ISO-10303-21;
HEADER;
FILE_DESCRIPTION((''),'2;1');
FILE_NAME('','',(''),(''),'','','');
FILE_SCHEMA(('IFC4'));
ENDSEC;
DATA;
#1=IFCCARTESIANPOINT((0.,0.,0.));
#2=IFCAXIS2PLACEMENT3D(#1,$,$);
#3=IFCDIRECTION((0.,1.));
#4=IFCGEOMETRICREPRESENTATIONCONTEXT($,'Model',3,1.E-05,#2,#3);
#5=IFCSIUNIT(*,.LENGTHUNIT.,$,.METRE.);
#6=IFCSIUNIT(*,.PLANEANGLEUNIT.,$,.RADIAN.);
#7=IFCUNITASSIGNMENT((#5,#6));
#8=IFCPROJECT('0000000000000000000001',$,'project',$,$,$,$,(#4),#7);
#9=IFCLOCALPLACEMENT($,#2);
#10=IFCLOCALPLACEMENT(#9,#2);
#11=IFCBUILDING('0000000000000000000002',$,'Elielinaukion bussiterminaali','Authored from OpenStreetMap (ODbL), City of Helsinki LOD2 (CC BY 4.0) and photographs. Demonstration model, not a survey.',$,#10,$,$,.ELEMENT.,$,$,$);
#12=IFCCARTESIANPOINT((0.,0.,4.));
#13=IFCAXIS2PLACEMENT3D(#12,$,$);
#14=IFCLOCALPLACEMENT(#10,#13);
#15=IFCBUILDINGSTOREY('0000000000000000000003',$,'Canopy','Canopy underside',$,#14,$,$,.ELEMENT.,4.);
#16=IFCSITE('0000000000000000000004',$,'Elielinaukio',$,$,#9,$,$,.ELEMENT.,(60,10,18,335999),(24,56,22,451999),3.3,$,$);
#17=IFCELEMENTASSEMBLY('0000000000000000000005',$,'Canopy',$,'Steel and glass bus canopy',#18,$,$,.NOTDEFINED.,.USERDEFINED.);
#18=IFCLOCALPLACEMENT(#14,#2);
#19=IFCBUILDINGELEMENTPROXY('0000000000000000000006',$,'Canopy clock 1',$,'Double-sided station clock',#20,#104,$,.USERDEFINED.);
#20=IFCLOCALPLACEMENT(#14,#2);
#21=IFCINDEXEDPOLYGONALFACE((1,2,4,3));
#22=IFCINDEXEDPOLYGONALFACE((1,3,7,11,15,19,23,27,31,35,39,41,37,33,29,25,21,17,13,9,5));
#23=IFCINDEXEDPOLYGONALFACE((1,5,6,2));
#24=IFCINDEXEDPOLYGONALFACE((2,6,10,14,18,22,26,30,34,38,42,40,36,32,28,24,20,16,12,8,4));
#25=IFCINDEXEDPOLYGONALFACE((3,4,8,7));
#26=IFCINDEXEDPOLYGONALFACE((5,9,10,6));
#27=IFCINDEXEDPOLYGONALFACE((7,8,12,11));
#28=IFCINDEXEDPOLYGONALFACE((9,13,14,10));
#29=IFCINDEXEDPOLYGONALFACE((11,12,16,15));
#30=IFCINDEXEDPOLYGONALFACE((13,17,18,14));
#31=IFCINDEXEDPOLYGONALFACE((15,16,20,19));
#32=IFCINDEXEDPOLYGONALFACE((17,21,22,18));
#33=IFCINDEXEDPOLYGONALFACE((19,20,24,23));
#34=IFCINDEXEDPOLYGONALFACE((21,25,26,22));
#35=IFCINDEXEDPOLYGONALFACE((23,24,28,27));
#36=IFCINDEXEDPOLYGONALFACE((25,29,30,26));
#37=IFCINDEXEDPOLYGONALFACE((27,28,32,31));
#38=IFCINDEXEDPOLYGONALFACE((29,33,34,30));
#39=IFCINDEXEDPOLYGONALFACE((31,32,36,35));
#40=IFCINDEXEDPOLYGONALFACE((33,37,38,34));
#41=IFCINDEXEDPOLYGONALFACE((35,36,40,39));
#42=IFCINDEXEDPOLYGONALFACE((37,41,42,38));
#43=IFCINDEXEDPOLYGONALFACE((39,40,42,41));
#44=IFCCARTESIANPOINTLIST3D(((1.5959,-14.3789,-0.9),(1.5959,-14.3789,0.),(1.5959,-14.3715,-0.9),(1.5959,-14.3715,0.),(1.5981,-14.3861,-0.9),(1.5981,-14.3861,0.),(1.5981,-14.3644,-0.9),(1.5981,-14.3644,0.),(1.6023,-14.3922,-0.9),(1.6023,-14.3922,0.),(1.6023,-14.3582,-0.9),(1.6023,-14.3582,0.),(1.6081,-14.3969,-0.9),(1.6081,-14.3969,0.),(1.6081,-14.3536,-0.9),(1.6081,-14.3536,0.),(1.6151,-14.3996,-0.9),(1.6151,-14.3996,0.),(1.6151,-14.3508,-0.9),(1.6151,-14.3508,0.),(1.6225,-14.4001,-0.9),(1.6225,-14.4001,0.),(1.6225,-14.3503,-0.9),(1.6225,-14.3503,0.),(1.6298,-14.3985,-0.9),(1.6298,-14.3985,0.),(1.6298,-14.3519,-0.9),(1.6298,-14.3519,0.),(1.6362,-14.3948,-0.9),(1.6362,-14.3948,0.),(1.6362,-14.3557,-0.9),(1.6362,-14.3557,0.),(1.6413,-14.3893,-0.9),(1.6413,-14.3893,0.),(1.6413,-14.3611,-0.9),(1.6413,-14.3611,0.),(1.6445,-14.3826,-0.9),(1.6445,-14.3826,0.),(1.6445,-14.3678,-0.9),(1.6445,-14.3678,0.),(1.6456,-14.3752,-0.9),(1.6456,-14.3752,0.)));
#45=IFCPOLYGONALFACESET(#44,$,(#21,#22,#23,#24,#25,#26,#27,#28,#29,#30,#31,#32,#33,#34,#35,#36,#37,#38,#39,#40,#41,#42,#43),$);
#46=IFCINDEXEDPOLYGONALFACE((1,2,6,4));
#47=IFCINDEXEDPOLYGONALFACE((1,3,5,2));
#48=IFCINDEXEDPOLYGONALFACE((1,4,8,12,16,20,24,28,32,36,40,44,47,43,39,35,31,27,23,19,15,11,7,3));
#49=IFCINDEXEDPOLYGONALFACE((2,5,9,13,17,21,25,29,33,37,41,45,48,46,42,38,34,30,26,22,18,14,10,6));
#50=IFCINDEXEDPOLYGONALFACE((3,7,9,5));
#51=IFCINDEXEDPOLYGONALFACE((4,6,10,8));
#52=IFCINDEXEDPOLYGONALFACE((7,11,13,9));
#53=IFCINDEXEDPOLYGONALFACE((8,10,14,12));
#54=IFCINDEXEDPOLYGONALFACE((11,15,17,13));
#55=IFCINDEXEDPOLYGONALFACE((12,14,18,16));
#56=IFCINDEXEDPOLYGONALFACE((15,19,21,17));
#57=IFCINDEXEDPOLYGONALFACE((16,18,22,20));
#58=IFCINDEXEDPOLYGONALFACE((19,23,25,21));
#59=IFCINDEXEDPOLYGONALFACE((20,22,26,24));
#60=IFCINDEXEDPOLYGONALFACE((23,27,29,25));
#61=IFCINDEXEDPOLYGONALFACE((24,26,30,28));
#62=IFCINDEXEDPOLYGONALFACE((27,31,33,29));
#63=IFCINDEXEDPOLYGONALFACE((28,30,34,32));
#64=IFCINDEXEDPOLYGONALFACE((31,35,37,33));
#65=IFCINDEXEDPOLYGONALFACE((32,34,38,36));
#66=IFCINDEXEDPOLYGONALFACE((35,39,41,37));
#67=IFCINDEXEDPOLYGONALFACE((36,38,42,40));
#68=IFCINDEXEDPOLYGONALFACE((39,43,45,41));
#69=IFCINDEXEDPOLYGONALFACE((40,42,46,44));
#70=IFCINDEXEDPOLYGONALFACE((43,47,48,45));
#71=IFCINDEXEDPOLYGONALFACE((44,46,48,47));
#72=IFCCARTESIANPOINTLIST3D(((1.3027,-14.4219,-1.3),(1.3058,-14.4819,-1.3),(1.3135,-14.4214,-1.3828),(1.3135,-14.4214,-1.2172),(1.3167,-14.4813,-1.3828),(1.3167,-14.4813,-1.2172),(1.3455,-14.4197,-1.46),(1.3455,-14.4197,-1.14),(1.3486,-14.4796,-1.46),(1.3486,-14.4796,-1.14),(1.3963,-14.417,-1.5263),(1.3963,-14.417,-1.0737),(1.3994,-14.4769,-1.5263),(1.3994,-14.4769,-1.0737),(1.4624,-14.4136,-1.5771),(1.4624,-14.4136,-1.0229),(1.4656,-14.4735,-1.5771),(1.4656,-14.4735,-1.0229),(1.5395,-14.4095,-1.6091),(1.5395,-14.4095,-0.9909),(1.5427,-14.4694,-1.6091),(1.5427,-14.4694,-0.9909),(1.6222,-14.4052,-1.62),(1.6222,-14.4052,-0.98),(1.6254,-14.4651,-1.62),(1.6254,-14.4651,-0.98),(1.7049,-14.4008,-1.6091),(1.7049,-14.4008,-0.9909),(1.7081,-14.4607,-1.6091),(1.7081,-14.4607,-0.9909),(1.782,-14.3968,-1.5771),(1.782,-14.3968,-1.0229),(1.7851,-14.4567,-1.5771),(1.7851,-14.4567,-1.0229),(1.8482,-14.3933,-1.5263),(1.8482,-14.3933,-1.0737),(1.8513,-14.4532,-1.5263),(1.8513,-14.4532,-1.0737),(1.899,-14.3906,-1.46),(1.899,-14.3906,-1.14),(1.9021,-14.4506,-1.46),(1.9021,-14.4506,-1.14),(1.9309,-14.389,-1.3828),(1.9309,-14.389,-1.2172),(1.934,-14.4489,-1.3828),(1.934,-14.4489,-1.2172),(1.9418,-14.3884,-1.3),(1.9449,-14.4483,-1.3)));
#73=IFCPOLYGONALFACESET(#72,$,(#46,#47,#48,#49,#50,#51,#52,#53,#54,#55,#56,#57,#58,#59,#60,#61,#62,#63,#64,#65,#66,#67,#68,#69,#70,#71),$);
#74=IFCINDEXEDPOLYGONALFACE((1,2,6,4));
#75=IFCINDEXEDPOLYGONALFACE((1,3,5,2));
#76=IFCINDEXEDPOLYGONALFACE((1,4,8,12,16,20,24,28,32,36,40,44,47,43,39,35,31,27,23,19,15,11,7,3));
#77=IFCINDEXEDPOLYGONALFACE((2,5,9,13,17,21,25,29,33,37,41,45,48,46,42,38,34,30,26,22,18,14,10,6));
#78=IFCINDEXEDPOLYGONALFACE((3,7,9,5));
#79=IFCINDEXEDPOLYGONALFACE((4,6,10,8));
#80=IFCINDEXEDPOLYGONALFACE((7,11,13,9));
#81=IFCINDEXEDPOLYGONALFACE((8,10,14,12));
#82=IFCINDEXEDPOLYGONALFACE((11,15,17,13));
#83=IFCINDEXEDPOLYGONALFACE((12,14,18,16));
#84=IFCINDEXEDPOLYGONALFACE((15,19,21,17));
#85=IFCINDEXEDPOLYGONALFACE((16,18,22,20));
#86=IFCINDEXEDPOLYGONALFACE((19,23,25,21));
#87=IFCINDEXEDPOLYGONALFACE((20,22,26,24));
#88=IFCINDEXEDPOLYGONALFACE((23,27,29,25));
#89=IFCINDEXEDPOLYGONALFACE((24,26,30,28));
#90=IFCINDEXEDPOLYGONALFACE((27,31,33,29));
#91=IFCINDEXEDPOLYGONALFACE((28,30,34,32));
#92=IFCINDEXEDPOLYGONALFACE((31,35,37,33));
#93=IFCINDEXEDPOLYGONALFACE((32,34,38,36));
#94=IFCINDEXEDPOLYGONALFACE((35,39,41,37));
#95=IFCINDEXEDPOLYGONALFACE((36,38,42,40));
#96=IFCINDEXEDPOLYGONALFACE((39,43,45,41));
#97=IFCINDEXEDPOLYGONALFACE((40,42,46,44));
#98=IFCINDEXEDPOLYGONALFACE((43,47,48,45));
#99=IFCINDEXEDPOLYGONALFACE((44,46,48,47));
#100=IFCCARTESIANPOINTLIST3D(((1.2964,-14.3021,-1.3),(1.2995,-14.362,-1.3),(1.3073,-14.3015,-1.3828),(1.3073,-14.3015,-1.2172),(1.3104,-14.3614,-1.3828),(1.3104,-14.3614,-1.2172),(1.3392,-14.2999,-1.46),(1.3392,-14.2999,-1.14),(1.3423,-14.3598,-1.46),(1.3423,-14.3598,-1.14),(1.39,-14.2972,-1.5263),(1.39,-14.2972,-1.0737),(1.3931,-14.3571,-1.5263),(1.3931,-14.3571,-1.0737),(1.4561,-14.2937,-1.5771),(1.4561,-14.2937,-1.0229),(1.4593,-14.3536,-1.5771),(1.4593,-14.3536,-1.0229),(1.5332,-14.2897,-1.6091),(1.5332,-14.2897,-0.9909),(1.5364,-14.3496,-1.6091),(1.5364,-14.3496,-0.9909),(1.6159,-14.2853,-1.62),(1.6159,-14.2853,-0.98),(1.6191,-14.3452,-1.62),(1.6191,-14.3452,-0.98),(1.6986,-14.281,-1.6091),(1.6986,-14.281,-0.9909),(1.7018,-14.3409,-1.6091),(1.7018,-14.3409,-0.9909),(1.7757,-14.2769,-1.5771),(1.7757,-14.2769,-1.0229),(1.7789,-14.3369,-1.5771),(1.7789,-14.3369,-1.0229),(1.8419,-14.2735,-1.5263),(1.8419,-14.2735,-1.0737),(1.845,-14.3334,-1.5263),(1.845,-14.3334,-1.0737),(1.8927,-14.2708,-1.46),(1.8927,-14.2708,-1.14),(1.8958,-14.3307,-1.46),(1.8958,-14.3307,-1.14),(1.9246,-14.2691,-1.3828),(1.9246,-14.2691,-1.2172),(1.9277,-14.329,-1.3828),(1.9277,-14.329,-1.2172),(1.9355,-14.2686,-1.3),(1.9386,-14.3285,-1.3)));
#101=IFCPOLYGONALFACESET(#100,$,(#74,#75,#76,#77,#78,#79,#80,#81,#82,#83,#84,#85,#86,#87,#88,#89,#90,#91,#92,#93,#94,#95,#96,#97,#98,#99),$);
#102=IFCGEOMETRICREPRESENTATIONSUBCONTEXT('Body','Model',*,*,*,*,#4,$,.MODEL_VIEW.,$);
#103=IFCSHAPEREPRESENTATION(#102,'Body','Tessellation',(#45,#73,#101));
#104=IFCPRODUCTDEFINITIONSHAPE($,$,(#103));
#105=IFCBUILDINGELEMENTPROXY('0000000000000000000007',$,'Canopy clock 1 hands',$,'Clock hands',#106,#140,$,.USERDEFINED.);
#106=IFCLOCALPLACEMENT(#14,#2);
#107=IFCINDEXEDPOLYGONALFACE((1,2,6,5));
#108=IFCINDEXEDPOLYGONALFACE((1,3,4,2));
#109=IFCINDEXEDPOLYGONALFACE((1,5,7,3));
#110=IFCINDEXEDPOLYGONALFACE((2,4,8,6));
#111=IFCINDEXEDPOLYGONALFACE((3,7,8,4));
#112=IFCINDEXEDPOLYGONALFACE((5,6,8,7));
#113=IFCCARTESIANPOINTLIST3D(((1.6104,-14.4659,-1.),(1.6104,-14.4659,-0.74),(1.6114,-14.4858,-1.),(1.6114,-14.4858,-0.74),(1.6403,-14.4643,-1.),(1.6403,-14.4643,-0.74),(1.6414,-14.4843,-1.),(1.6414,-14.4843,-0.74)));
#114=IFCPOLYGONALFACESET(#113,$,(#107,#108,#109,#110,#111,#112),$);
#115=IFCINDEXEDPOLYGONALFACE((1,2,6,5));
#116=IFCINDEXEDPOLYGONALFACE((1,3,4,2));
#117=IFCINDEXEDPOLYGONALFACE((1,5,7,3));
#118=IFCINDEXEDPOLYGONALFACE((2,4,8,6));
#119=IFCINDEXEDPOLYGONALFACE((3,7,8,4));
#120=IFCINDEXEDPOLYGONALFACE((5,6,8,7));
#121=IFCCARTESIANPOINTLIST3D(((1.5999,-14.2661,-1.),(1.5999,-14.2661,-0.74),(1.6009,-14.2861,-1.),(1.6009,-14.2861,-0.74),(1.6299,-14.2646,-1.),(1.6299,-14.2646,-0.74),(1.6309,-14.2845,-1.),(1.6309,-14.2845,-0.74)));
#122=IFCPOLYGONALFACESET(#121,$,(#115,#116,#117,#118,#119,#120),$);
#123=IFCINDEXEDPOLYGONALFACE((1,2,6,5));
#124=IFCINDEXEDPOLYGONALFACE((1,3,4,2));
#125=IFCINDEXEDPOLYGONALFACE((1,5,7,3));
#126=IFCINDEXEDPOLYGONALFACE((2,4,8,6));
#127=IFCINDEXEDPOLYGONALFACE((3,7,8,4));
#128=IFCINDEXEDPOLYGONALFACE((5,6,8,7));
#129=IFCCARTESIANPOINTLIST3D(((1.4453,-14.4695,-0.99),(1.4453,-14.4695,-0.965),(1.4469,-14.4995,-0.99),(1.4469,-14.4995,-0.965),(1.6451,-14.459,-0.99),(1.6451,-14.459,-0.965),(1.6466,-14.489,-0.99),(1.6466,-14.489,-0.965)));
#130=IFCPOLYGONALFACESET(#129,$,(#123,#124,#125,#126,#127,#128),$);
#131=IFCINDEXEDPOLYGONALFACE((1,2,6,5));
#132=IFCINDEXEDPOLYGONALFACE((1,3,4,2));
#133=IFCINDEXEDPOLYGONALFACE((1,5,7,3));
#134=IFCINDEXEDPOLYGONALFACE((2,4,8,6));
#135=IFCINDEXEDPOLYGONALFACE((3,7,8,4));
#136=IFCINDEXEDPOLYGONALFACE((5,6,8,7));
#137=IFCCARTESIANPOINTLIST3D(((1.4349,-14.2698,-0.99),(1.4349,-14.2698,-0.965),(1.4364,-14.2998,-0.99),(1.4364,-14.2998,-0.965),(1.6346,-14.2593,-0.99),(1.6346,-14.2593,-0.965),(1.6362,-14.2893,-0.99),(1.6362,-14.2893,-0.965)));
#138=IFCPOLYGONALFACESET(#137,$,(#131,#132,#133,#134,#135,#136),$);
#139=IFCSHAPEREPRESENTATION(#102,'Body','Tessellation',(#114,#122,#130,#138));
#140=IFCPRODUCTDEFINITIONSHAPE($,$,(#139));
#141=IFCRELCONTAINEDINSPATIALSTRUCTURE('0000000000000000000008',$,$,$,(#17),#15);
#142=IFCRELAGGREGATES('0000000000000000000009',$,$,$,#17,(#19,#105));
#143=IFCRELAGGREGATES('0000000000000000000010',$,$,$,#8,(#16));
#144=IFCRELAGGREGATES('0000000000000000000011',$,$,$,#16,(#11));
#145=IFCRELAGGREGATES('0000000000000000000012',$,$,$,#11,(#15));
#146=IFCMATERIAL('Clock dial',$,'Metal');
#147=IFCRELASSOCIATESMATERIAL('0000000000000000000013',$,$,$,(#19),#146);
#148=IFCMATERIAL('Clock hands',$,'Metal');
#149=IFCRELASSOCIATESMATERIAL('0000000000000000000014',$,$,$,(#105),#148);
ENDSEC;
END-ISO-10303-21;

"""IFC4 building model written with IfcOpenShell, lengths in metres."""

from ifc_helpers import new_model, si_unit, direction, frame, frame_2d, origin, origin_2d_with_axis, place, context, subcontext, project, spatial, polyline, rectangle, circle, outline, extrude, material, element, aggregate, save


model = new_model("IFC4")

# Units and contexts
model_context = context("Model", 3, precision=1e-05, world=origin(), true_north=direction((0.0, 1.0)))
body_context = subcontext(model_context, "Body", "Model", "MODEL_VIEW")
ifc_project = project(units=[si_unit("LENGTHUNIT", "METRE"), si_unit("PLANEANGLEUNIT", "RADIAN")], contexts=[model_context])

# Site, building, storey
site_placement = place(None, origin())
site = spatial("IfcSite", under=ifc_project, at=site_placement, Name="Elielinaukio", CompositionType="ELEMENT", RefLatitude=(60, 10, 18, 335999), RefLongitude=(24, 56, 22, 451999), RefElevation=3.3)
building_placement = place(site_placement, origin())
building = spatial("IfcBuilding", under=site, at=building_placement, Name="Elielinaukion bussiterminaali", Description="Authored from OpenStreetMap (ODbL), City of Helsinki LOD2 (CC BY 4.0) and photographs. Demonstration model, not a survey.", CompositionType="ELEMENT")
storey_placement = place(building_placement, frame((0.0, 0.0, 4.0)))
storey = spatial("IfcBuildingStorey", under=building, at=storey_placement, Name="Canopy", Description="Canopy underside", CompositionType="ELEMENT", Elevation=4.0)

# Element assembly, building element proxies
assembly_placement = place(building_placement, origin())
assembly = element("IfcElementAssembly", 1, at=assembly_placement, inside=storey, Name="Canopy", ObjectType="Steel and glass bus canopy", AssemblyPlace="NOTDEFINED", PredefinedType="USERDEFINED")
ifc_material_1 = material(Name="Clock dial", Category="Metal")
proxy_1_placement = place(building_placement, origin())
proxy_1 = element("IfcBuildingElementProxy", 2, at=proxy_1_placement, material=ifc_material_1, Name="Canopy clock 1", ObjectType="Double-sided station clock", PredefinedType="USERDEFINED", context=body_context, shape_type="SweptSolid", body=[
    extrude(circle(Radius=0.025, at=origin_2d_with_axis()), frame((1.6206, -14.3752, 3.1)), (0.0, 0.0, 1.0), 0.9),
    extrude(outline(polyline([(0.32, 0.0), (0.3091, 0.0828), (0.2771, 0.16), (0.2263, 0.2263), (0.16, 0.2771), (0.0828, 0.3091), (0.0, 0.32), (-0.0828, 0.3091), (-0.16, 0.2771), (-0.2263, 0.2263), (-0.2771, 0.16), (-0.3091, 0.0828), (-0.32, 0.0), (-0.3091, -0.0828), (-0.2771, -0.16), (-0.2263, -0.2263), (-0.16, -0.2771), (-0.0828, -0.3091), (0.0, -0.32), (0.0828, -0.3091), (0.16, -0.2771), (0.2263, -0.2263), (0.2771, -0.16), (0.3091, -0.0828), (0.32, 0.0)])), frame((1.6254, -14.4651, 2.7), z_axis=(-0.052408, 0.998626, 0.0), x_axis=(-0.998626, -0.052408, 0.0)), (0.0, 0.0, 1.0), 0.06),
    extrude(outline(polyline([(0.32, 0.0), (0.3091, 0.0828), (0.2771, 0.16), (0.2263, 0.2263), (0.16, 0.2771), (0.0828, 0.3091), (0.0, 0.32), (-0.0828, 0.3091), (-0.16, 0.2771), (-0.2263, 0.2263), (-0.2771, 0.16), (-0.3091, 0.0828), (-0.32, 0.0), (-0.3091, -0.0828), (-0.2771, -0.16), (-0.2263, -0.2263), (-0.16, -0.2771), (-0.0828, -0.3091), (0.0, -0.32), (0.0828, -0.3091), (0.16, -0.2771), (0.2263, -0.2263), (0.2771, -0.16), (0.3091, -0.0828), (0.32, 0.0)])), frame((1.6191, -14.3452, 2.7), z_axis=(-0.052408, 0.998626, 0.0), x_axis=(-0.998626, -0.052408, 0.0)), (0.0, 0.0, 1.0), 0.06),
])
ifc_material_2 = material(Name="Clock hands", Category="Metal")
proxy_2_placement = place(building_placement, origin())
proxy_2 = element("IfcBuildingElementProxy", 3, at=proxy_2_placement, material=ifc_material_2, Name="Canopy clock 1 hands", ObjectType="Clock hands", PredefinedType="USERDEFINED", context=body_context, shape_type="SweptSolid", body=[
    extrude(rectangle(XDim=0.03, YDim=0.02, at=frame_2d((0.0, 0.0), x_axis=(-0.998626, -0.052408))), frame((1.6259, -14.4751, 3.0)), (0.0, 0.0, 1.0), 0.26),
    extrude(rectangle(XDim=0.03, YDim=0.02, at=frame_2d((0.0, 0.0), x_axis=(-0.998626, -0.052408))), frame((1.6154, -14.2753, 3.0)), (0.0, 0.0, 1.0), 0.26),
    extrude(rectangle(XDim=0.03, YDim=0.2, at=frame_2d((0.0, 0.0), x_axis=(-0.052408, 0.998626))), frame((1.546, -14.4793, 3.01)), (0.0, 0.0, 1.0), 0.025),
    extrude(rectangle(XDim=0.03, YDim=0.2, at=frame_2d((0.0, 0.0), x_axis=(-0.052408, 0.998626))), frame((1.5355, -14.2795, 3.01)), (0.0, 0.0, 1.0), 0.025),
])
aggregate(assembly, [proxy_1, proxy_2])

save(model, "model.ifc")
